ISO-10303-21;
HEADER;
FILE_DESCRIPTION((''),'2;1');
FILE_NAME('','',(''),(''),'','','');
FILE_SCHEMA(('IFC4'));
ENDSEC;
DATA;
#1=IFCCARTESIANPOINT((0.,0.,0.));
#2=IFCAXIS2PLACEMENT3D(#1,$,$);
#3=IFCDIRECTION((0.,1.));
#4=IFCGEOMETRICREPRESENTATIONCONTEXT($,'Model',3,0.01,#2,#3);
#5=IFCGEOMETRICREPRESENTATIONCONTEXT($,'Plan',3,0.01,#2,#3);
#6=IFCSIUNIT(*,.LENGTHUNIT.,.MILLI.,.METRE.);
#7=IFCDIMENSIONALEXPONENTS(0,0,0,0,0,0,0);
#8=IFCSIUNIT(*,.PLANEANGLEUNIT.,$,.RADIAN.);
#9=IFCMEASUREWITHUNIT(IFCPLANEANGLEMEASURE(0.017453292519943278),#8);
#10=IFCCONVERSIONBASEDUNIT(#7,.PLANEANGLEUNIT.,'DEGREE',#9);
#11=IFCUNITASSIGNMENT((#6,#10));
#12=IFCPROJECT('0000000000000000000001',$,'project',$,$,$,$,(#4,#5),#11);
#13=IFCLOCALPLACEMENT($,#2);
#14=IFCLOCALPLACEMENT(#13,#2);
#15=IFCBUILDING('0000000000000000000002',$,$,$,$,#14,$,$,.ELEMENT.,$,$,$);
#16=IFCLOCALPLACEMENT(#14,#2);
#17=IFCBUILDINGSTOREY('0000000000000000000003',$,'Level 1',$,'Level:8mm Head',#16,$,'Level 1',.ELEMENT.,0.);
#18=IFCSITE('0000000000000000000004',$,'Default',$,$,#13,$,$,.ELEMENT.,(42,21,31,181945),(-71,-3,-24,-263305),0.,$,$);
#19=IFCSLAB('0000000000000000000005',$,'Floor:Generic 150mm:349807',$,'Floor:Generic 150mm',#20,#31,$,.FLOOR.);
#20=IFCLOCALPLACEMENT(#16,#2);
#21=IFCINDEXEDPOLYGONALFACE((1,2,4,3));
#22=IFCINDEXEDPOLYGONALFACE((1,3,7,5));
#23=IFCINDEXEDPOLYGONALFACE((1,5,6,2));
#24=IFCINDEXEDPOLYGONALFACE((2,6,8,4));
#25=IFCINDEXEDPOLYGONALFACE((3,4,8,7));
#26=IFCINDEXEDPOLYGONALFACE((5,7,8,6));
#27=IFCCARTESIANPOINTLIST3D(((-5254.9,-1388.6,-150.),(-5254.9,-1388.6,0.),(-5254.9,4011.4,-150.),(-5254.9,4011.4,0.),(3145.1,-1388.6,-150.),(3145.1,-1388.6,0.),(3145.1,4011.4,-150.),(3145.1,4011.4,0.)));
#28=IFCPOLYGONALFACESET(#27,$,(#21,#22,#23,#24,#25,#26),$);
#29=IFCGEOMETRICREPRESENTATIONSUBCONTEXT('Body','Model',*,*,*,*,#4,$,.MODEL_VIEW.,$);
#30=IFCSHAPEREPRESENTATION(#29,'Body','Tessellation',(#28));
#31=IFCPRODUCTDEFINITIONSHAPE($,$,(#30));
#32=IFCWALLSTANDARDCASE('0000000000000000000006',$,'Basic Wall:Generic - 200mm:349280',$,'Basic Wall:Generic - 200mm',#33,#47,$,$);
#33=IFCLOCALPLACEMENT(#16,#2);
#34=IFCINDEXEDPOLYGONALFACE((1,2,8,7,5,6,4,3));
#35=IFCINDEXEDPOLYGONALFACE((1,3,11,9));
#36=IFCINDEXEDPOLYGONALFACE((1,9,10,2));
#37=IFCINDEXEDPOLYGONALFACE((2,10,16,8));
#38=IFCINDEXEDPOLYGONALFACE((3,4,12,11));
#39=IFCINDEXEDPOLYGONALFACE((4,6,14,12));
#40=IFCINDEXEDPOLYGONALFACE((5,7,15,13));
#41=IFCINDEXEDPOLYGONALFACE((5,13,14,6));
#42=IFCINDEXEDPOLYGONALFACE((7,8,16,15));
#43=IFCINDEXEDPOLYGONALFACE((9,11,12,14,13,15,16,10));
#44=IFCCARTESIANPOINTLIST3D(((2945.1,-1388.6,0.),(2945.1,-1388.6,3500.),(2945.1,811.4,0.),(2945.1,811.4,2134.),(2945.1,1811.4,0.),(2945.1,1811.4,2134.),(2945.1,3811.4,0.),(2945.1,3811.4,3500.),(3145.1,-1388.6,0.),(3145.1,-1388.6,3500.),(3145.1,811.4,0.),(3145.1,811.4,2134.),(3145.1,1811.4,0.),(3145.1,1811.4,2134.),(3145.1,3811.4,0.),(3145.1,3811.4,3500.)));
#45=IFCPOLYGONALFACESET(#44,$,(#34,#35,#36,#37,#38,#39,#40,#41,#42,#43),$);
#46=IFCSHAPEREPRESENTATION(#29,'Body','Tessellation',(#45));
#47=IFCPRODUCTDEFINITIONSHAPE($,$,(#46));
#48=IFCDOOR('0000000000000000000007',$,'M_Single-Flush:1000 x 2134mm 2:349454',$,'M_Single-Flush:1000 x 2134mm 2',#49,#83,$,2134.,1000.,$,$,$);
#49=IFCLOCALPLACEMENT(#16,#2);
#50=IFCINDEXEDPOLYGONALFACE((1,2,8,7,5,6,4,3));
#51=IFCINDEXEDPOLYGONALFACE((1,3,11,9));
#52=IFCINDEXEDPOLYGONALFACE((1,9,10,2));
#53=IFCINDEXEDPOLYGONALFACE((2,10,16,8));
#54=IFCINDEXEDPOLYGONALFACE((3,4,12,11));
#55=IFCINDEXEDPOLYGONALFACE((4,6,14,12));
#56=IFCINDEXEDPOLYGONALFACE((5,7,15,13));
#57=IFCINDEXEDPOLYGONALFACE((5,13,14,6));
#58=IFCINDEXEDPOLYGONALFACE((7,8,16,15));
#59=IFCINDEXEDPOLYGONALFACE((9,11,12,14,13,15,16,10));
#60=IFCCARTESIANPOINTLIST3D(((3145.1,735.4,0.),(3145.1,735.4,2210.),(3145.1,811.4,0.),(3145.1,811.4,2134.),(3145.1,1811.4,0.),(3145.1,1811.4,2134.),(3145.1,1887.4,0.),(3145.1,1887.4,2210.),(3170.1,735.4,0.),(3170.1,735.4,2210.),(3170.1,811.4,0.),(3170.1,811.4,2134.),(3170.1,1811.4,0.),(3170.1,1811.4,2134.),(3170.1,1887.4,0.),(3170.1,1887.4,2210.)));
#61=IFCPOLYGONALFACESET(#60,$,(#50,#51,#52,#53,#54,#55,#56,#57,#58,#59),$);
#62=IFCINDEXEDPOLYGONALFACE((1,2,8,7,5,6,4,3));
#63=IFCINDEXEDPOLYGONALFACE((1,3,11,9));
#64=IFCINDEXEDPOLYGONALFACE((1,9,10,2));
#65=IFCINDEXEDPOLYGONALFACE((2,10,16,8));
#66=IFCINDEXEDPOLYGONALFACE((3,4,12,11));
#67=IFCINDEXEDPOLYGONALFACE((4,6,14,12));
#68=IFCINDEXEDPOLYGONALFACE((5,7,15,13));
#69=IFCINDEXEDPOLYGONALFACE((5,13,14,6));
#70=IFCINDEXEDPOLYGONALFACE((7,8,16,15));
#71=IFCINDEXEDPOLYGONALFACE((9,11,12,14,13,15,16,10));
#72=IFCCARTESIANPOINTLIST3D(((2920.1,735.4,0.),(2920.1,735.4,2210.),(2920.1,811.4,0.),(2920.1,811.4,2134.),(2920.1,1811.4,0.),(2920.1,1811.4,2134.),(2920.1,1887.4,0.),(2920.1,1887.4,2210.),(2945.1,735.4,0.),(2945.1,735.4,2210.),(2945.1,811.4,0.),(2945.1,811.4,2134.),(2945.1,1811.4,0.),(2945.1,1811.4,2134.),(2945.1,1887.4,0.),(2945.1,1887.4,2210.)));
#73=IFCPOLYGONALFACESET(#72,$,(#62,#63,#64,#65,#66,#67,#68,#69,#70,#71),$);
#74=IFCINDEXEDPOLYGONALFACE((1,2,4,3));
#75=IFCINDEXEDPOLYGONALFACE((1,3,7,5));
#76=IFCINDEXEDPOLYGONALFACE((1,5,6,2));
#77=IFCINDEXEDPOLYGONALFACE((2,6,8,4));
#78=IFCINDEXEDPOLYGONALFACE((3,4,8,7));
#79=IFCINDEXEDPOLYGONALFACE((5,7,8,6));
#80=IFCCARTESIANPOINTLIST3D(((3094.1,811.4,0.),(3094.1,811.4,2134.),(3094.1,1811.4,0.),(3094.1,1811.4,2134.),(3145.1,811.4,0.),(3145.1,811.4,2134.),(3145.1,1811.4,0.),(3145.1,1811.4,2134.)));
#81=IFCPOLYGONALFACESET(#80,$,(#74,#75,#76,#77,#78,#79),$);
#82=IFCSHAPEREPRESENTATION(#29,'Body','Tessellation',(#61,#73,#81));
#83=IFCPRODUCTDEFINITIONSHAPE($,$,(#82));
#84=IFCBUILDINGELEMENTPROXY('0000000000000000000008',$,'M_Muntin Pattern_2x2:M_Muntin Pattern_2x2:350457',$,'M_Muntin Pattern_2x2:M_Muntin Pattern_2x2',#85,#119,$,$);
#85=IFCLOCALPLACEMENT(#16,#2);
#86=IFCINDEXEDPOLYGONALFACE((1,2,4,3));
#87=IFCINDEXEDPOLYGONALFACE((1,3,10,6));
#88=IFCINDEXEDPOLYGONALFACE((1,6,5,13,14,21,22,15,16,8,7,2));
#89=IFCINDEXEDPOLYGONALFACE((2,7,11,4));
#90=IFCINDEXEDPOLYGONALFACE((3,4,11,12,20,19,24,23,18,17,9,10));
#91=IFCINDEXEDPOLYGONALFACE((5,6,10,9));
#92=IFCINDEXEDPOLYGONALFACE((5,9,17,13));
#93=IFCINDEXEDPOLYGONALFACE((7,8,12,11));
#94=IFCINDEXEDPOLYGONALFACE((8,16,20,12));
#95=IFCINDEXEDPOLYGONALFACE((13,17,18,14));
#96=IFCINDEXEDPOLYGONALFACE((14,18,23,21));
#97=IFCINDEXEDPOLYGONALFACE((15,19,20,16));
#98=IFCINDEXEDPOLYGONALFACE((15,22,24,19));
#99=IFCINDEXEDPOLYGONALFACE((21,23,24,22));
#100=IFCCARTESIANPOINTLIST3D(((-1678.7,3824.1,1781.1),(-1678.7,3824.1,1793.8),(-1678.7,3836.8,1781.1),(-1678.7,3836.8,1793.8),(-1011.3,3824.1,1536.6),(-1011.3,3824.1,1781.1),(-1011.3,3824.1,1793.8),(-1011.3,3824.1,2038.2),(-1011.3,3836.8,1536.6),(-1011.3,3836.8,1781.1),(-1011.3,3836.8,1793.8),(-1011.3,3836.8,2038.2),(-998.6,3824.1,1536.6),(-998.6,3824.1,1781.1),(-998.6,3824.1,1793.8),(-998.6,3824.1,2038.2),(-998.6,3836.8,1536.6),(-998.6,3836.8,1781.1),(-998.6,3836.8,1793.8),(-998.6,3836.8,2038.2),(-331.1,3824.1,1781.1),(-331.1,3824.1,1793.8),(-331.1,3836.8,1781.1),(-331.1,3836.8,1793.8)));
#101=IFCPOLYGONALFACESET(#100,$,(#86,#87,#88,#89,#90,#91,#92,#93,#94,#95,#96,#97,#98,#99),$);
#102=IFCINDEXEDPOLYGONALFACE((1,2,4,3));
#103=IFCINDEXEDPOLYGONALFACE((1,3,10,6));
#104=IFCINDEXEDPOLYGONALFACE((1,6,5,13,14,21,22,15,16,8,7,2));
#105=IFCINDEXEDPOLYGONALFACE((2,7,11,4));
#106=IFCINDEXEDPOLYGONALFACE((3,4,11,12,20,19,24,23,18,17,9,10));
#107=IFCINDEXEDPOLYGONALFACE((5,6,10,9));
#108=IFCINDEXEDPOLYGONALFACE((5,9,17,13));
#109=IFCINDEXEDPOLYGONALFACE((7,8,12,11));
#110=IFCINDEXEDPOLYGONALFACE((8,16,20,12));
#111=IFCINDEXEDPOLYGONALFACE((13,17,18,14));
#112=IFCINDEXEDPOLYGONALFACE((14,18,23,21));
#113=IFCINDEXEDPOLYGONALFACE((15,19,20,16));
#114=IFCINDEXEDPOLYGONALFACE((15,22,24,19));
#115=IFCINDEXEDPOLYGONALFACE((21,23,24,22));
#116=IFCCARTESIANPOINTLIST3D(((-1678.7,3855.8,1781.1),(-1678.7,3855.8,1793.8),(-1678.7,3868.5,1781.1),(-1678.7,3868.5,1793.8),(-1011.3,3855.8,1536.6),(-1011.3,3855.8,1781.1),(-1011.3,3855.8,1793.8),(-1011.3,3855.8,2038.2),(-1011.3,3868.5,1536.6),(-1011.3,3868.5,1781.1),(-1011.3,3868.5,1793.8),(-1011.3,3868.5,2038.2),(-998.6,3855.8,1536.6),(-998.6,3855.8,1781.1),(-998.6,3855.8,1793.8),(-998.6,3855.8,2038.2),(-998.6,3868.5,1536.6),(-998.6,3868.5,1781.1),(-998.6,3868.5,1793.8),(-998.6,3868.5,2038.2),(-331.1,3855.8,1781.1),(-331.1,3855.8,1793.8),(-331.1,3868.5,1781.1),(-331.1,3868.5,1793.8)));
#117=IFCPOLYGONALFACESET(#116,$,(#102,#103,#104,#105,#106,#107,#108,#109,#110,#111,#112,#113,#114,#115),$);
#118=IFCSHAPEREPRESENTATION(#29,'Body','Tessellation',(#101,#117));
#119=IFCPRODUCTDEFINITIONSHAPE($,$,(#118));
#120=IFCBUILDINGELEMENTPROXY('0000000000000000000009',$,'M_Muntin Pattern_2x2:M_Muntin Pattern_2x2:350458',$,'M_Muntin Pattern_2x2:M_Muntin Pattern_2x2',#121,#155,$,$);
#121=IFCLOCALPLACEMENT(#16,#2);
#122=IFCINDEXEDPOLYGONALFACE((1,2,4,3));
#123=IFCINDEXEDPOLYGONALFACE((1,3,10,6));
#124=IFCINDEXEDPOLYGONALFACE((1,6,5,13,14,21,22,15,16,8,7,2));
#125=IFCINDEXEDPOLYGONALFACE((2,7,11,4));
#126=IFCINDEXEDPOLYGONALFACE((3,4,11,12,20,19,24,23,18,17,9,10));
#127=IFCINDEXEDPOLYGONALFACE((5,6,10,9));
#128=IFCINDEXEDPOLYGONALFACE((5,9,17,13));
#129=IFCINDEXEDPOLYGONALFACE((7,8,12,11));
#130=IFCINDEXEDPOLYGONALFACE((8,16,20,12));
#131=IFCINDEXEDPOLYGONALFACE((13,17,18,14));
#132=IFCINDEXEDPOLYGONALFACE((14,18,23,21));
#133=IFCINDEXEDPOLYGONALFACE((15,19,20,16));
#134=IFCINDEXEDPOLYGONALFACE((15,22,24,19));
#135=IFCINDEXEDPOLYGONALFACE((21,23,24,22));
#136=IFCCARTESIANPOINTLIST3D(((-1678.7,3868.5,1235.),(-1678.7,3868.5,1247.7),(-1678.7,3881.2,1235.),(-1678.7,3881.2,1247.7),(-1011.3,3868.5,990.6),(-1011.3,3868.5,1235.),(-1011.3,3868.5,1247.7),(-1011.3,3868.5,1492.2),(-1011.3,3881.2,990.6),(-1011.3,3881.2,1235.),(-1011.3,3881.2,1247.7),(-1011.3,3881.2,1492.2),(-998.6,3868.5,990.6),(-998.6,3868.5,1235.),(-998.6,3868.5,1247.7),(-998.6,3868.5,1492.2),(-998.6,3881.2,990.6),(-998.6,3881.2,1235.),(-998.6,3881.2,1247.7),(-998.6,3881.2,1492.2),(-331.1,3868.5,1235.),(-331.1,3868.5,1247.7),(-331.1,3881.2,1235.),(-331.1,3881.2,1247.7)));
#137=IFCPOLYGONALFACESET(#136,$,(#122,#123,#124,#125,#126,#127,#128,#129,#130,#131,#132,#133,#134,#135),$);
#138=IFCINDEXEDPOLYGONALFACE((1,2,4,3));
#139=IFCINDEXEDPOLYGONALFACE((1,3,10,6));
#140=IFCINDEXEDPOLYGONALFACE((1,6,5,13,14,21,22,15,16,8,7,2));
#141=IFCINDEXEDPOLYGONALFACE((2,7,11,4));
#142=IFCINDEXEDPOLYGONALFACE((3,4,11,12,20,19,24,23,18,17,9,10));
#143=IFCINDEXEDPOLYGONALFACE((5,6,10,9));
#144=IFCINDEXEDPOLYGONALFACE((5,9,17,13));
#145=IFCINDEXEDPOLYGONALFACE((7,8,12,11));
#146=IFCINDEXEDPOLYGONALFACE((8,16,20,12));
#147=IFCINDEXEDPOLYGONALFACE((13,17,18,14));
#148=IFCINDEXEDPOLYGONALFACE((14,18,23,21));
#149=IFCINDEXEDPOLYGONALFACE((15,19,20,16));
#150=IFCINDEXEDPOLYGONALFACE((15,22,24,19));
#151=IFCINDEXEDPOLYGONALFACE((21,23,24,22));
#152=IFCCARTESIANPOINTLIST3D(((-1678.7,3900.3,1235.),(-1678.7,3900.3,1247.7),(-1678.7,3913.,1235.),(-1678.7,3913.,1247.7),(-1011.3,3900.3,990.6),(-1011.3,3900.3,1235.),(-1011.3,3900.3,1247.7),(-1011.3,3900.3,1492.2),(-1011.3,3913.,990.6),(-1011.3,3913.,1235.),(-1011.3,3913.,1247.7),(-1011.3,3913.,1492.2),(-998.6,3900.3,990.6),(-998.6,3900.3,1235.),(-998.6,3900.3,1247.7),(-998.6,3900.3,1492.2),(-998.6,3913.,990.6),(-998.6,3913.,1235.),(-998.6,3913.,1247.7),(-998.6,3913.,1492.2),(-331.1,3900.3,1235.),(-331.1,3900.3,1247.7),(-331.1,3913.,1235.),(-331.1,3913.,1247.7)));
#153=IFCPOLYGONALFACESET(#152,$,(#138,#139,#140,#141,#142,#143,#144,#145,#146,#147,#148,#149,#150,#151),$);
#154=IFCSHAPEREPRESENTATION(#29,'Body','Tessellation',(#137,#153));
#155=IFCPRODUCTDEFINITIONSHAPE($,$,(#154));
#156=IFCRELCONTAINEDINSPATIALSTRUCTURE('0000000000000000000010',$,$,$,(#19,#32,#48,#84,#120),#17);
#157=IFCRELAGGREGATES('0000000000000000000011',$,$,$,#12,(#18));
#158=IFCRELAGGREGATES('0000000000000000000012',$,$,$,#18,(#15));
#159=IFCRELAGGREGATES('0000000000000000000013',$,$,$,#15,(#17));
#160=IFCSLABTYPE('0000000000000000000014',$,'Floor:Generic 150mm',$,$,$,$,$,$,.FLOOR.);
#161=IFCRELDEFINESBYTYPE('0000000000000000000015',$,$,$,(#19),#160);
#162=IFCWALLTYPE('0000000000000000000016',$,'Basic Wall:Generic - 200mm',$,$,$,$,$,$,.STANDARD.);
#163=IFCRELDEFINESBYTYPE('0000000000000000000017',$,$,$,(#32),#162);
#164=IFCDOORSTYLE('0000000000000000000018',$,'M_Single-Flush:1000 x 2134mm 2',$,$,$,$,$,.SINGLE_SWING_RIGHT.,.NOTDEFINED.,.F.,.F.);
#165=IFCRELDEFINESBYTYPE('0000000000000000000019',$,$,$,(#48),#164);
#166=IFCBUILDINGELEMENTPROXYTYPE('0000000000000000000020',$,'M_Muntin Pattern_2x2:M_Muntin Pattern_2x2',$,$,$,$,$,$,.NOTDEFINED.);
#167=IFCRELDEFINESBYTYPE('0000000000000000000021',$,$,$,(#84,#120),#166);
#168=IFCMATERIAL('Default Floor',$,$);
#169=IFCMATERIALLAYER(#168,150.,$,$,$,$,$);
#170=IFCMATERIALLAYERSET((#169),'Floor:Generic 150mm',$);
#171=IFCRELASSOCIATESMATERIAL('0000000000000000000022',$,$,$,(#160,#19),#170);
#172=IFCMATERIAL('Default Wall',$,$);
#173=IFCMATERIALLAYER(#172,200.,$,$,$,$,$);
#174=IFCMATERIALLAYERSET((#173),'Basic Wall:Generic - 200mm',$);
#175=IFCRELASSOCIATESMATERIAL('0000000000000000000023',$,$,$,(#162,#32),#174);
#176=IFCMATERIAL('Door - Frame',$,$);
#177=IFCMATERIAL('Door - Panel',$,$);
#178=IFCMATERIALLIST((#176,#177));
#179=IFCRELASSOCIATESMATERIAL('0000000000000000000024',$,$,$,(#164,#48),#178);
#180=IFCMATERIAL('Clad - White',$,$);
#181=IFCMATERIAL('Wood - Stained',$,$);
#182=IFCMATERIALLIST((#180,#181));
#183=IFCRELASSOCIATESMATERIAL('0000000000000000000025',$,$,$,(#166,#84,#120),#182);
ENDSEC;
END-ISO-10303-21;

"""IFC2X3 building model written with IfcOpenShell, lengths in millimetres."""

from ifc_helpers import new_model, entity, si_unit, converted_unit, direction, frame, frame_2d, origin, place, context, subcontext, project, spatial, polyline, rectangle, outline, extrude, source, transform, mapped, material, material_list, layer, layer_set, layer_usage, type_object, type_shapes, element, fill, save


model = new_model("IFC2X3")

# Units and contexts
model_context = context("Model", 3, precision=0.01, world=origin(), true_north=direction((0.0, 1.0)))
plan_context = context("Plan", 3, precision=0.01, world=origin(), true_north=direction((0.0, 1.0)))
body_context = subcontext(model_context, "Body", "Model", "MODEL_VIEW")
ifc_project = project(units=[si_unit("LENGTHUNIT", "METRE", prefix="MILLI"), converted_unit("PLANEANGLEUNIT", "DEGREE", entity("IfcPlaneAngleMeasure", 0.017453292519943278), si_unit("PLANEANGLEUNIT", "RADIAN"), dimensions=[0, 0, 0, 0, 0, 0, 0])], contexts=[model_context, plan_context])

# Site, building, storey
site_placement = place(None, origin())
site = spatial("IfcSite", under=ifc_project, at=site_placement, Name="Default", CompositionType="ELEMENT", RefLatitude=(42, 21, 31, 181945), RefLongitude=(-71, -3, -24, -263305), RefElevation=0.0)
building_placement = place(site_placement, origin())
building = spatial("IfcBuilding", under=site, at=building_placement, CompositionType="ELEMENT")
storey_placement = place(building_placement, origin())
storey = spatial("IfcBuildingStorey", under=building, at=storey_placement, Name="Level 1", ObjectType="Level:8mm Head", LongName="Level 1", CompositionType="ELEMENT", Elevation=0.0)

# Slab
ifc_material_1 = material(Name="Default Floor")
ifc_layer_1 = layer(ifc_material_1, 150.0)
ifc_layer_set_1 = layer_set([ifc_layer_1], Name="Floor:Generic 150mm")
ifc_layer_usage_1 = layer_usage(ifc_layer_set_1, "AXIS3", "POSITIVE", 0.0)
slab_type = type_object("IfcSlabType", Name="Floor:Generic 150mm", PredefinedType="FLOOR", material=ifc_layer_set_1)
slab_placement = place(storey_placement, origin())
element("IfcSlab", 1, at=slab_placement, inside=storey, type_object=slab_type, material=ifc_layer_usage_1, Name="Floor:Generic 150mm:349807", ObjectType="Floor:Generic 150mm", PredefinedType="FLOOR", context=body_context, shape_type="SweptSolid", body=[
    extrude(rectangle(XDim=5400.0, YDim=8400.0, at=frame_2d((0.0, 0.0), x_axis=(1.0, 0.0))), frame((-1054.9, 1311.4, 0.0), z_axis=(0.0, 0.0, -1.0), x_axis=(0.0, 1.0, 0.0)), (0.0, 0.0, 1.0), 150.0),
])

# Wall, opening, door
ifc_material_2 = material(Name="Default Wall")
ifc_layer_2 = layer(ifc_material_2, 200.0)
ifc_layer_set_2 = layer_set([ifc_layer_2], Name="Basic Wall:Generic - 200mm")
ifc_layer_usage_2 = layer_usage(ifc_layer_set_2, "AXIS2", "NEGATIVE", 100.0)
wall_type = type_object("IfcWallType", Name="Basic Wall:Generic - 200mm", PredefinedType="STANDARD", material=ifc_layer_set_2)
wall_1_placement = place(storey_placement, frame((3045.1, 3811.4, 0.0), z_axis=(0.0, 0.0, 1.0), x_axis=(0.0, -1.0, 0.0)))
wall_1 = element("IfcWallStandardCase", 2, at=wall_1_placement, inside=storey, type_object=wall_type, material=ifc_layer_usage_2, Name="Basic Wall:Generic - 200mm:349280", ObjectType="Basic Wall:Generic - 200mm", context=body_context, shape_type="SweptSolid", body=[
    extrude(rectangle(XDim=5200.0, YDim=200.0, at=frame_2d((2600.0, 0.0), x_axis=(-1.0, 0.0))), origin(), (0.0, 0.0, 1.0), 3500.0),
])
opening_1_placement = place(wall_1_placement, frame((2000.0, -100.0, 0.0)))
opening_1 = element("IfcOpeningElement", 3, at=opening_1_placement, cuts=wall_1, ObjectType="Opening", context=body_context, shape_type="SweptSolid", body=[
    extrude(rectangle(XDim=1000.0, YDim=2134.0, at=frame_2d((1067.0, 500.0), x_axis=(0.0, 1.0))), frame((0.0, 0.0, 0.0), z_axis=(0.0, 1.0, 0.0), x_axis=(0.0, 0.0, 1.0)), (0.0, 0.0, 1.0), 200.0),
])
ifc_material_3 = material(Name="Door - Frame")
ifc_material_4 = material(Name="Door - Panel")
ifc_material_list_1 = material_list([ifc_material_3, ifc_material_4])
door_style = type_object("IfcDoorStyle", Name="M_Single-Flush:1000 x 2134mm 2", ConstructionType="NOTDEFINED", OperationType="SINGLE_SWING_RIGHT", ParameterTakesPrecedence=False, Sizeable=False, material=ifc_material_list_1)
shared_shape_1 = source(origin(), body_context, "Body", "SweptSolid", [
    extrude(outline(polyline([(-576.0, -1124.0), (576.0, -1124.0), (576.0, 1086.0), (500.0, 1086.0), (500.0, -1048.0), (-500.0, -1048.0), (-500.0, 1086.0), (-576.0, 1086.0), (-576.0, -1124.0)])), frame((500.0, 200.0, 1086.0), z_axis=(0.0, 1.0, 0.0), x_axis=(1.0, 0.0, 0.0)), (0.0, 0.0, 1.0), 25.0),
    extrude(outline(polyline([(-1124.0, -576.0), (1086.0, -576.0), (1086.0, -500.0), (-1048.0, -500.0), (-1048.0, 500.0), (1086.0, 500.0), (1086.0, 576.0), (-1124.0, 576.0), (-1124.0, -576.0)])), frame((500.0, -25.0, 1086.0), z_axis=(0.0, 1.0, 0.0), x_axis=(0.0, 0.0, -1.0)), (0.0, 0.0, 1.0), 25.0),
    extrude(rectangle(XDim=51.0, YDim=1000.0, at=frame_2d((0.0, 0.0), x_axis=(1.0, 0.0))), frame((500.0, 174.5, 0.0), z_axis=(0.0, 0.0, 1.0), x_axis=(0.0, 1.0, 0.0)), (0.0, 0.0, 1.0), 2134.0),
])
type_shapes(door_style, [shared_shape_1])
door_placement = place(opening_1_placement, origin())
door = element("IfcDoor", 4, at=door_placement, inside=storey, type_object=door_style, material=ifc_material_list_1, Name="M_Single-Flush:1000 x 2134mm 2:349454", ObjectType="M_Single-Flush:1000 x 2134mm 2", OverallHeight=2134.0, OverallWidth=1000.0, context=body_context, shape_type="MappedRepresentation", body=[
    mapped(shared_shape_1, transform((0.0, 0.0, 0.0), scale=1.0)),
])
fill(opening_1, door)

# Shared definitions
ifc_material_5 = material(Name="Wood - Stained")

# Building element proxies
ifc_material_6 = material(Name="Clad - White")
ifc_material_list_2 = material_list([ifc_material_6, ifc_material_5])
building_element_proxy_type_1 = type_object("IfcBuildingElementProxyType", Name="M_Muntin Pattern_2x2:M_Muntin Pattern_2x2", PredefinedType="NOTDEFINED", material=ifc_material_list_2)
shared_shape_2 = source(origin(), body_context, "Body", "SweptSolid", [
    extrude(outline(polyline([(6.4, -6.4), (250.8, -6.4), (250.8, 6.3), (6.4, 6.3), (6.4, 673.8), (-6.3, 673.8), (-6.3, 6.3), (-250.8, 6.3), (-250.8, -6.4), (-6.3, -6.4), (-6.3, -673.8), (6.4, -673.8), (6.4, -6.4)])), frame((0.0, 9.5, 250.8), z_axis=(0.0, 1.0, 0.0), x_axis=(0.0, 0.0, 1.0)), (0.0, 0.0, 1.0), 12.7),
    extrude(outline(polyline([(6.4, -6.4), (250.8, -6.4), (250.8, 6.3), (6.4, 6.3), (6.4, 673.8), (-6.3, 673.8), (-6.3, 6.3), (-250.8, 6.3), (-250.8, -6.4), (-6.3, -6.4), (-6.3, -673.8), (6.4, -673.8), (6.4, -6.4)])), frame((0.0, -22.2, 250.8), z_axis=(0.0, 1.0, 0.0), x_axis=(0.0, 0.0, 1.0)), (0.0, 0.0, 1.0), 12.7),
])
type_shapes(building_element_proxy_type_1, [shared_shape_2])
for number, where, z_axis, x_axis, name in (
    (5, (-1004.9, 3846.3, 1536.6), (0.0, 0.0, 1.0), (-1.0, 0.0, 0.0), "M_Muntin Pattern_2x2:M_Muntin Pattern_2x2:350457"),
    (6, (-1004.9, 3890.7, 990.6), (0.0, 0.0, 1.0), (-1.0, 0.0, 0.0), "M_Muntin Pattern_2x2:M_Muntin Pattern_2x2:350458"),
):
    element("IfcBuildingElementProxy", number, at=place(storey_placement, frame(where, z_axis=z_axis, x_axis=x_axis)), inside=storey, type_object=building_element_proxy_type_1, material=ifc_material_list_2, Name=name, ObjectType="M_Muntin Pattern_2x2:M_Muntin Pattern_2x2", context=body_context, shape_type="MappedRepresentation", body=[
        mapped(shared_shape_2, transform((0.0, 0.0, 0.0), scale=1.0)),
    ])

save(model, "model.ifc")
